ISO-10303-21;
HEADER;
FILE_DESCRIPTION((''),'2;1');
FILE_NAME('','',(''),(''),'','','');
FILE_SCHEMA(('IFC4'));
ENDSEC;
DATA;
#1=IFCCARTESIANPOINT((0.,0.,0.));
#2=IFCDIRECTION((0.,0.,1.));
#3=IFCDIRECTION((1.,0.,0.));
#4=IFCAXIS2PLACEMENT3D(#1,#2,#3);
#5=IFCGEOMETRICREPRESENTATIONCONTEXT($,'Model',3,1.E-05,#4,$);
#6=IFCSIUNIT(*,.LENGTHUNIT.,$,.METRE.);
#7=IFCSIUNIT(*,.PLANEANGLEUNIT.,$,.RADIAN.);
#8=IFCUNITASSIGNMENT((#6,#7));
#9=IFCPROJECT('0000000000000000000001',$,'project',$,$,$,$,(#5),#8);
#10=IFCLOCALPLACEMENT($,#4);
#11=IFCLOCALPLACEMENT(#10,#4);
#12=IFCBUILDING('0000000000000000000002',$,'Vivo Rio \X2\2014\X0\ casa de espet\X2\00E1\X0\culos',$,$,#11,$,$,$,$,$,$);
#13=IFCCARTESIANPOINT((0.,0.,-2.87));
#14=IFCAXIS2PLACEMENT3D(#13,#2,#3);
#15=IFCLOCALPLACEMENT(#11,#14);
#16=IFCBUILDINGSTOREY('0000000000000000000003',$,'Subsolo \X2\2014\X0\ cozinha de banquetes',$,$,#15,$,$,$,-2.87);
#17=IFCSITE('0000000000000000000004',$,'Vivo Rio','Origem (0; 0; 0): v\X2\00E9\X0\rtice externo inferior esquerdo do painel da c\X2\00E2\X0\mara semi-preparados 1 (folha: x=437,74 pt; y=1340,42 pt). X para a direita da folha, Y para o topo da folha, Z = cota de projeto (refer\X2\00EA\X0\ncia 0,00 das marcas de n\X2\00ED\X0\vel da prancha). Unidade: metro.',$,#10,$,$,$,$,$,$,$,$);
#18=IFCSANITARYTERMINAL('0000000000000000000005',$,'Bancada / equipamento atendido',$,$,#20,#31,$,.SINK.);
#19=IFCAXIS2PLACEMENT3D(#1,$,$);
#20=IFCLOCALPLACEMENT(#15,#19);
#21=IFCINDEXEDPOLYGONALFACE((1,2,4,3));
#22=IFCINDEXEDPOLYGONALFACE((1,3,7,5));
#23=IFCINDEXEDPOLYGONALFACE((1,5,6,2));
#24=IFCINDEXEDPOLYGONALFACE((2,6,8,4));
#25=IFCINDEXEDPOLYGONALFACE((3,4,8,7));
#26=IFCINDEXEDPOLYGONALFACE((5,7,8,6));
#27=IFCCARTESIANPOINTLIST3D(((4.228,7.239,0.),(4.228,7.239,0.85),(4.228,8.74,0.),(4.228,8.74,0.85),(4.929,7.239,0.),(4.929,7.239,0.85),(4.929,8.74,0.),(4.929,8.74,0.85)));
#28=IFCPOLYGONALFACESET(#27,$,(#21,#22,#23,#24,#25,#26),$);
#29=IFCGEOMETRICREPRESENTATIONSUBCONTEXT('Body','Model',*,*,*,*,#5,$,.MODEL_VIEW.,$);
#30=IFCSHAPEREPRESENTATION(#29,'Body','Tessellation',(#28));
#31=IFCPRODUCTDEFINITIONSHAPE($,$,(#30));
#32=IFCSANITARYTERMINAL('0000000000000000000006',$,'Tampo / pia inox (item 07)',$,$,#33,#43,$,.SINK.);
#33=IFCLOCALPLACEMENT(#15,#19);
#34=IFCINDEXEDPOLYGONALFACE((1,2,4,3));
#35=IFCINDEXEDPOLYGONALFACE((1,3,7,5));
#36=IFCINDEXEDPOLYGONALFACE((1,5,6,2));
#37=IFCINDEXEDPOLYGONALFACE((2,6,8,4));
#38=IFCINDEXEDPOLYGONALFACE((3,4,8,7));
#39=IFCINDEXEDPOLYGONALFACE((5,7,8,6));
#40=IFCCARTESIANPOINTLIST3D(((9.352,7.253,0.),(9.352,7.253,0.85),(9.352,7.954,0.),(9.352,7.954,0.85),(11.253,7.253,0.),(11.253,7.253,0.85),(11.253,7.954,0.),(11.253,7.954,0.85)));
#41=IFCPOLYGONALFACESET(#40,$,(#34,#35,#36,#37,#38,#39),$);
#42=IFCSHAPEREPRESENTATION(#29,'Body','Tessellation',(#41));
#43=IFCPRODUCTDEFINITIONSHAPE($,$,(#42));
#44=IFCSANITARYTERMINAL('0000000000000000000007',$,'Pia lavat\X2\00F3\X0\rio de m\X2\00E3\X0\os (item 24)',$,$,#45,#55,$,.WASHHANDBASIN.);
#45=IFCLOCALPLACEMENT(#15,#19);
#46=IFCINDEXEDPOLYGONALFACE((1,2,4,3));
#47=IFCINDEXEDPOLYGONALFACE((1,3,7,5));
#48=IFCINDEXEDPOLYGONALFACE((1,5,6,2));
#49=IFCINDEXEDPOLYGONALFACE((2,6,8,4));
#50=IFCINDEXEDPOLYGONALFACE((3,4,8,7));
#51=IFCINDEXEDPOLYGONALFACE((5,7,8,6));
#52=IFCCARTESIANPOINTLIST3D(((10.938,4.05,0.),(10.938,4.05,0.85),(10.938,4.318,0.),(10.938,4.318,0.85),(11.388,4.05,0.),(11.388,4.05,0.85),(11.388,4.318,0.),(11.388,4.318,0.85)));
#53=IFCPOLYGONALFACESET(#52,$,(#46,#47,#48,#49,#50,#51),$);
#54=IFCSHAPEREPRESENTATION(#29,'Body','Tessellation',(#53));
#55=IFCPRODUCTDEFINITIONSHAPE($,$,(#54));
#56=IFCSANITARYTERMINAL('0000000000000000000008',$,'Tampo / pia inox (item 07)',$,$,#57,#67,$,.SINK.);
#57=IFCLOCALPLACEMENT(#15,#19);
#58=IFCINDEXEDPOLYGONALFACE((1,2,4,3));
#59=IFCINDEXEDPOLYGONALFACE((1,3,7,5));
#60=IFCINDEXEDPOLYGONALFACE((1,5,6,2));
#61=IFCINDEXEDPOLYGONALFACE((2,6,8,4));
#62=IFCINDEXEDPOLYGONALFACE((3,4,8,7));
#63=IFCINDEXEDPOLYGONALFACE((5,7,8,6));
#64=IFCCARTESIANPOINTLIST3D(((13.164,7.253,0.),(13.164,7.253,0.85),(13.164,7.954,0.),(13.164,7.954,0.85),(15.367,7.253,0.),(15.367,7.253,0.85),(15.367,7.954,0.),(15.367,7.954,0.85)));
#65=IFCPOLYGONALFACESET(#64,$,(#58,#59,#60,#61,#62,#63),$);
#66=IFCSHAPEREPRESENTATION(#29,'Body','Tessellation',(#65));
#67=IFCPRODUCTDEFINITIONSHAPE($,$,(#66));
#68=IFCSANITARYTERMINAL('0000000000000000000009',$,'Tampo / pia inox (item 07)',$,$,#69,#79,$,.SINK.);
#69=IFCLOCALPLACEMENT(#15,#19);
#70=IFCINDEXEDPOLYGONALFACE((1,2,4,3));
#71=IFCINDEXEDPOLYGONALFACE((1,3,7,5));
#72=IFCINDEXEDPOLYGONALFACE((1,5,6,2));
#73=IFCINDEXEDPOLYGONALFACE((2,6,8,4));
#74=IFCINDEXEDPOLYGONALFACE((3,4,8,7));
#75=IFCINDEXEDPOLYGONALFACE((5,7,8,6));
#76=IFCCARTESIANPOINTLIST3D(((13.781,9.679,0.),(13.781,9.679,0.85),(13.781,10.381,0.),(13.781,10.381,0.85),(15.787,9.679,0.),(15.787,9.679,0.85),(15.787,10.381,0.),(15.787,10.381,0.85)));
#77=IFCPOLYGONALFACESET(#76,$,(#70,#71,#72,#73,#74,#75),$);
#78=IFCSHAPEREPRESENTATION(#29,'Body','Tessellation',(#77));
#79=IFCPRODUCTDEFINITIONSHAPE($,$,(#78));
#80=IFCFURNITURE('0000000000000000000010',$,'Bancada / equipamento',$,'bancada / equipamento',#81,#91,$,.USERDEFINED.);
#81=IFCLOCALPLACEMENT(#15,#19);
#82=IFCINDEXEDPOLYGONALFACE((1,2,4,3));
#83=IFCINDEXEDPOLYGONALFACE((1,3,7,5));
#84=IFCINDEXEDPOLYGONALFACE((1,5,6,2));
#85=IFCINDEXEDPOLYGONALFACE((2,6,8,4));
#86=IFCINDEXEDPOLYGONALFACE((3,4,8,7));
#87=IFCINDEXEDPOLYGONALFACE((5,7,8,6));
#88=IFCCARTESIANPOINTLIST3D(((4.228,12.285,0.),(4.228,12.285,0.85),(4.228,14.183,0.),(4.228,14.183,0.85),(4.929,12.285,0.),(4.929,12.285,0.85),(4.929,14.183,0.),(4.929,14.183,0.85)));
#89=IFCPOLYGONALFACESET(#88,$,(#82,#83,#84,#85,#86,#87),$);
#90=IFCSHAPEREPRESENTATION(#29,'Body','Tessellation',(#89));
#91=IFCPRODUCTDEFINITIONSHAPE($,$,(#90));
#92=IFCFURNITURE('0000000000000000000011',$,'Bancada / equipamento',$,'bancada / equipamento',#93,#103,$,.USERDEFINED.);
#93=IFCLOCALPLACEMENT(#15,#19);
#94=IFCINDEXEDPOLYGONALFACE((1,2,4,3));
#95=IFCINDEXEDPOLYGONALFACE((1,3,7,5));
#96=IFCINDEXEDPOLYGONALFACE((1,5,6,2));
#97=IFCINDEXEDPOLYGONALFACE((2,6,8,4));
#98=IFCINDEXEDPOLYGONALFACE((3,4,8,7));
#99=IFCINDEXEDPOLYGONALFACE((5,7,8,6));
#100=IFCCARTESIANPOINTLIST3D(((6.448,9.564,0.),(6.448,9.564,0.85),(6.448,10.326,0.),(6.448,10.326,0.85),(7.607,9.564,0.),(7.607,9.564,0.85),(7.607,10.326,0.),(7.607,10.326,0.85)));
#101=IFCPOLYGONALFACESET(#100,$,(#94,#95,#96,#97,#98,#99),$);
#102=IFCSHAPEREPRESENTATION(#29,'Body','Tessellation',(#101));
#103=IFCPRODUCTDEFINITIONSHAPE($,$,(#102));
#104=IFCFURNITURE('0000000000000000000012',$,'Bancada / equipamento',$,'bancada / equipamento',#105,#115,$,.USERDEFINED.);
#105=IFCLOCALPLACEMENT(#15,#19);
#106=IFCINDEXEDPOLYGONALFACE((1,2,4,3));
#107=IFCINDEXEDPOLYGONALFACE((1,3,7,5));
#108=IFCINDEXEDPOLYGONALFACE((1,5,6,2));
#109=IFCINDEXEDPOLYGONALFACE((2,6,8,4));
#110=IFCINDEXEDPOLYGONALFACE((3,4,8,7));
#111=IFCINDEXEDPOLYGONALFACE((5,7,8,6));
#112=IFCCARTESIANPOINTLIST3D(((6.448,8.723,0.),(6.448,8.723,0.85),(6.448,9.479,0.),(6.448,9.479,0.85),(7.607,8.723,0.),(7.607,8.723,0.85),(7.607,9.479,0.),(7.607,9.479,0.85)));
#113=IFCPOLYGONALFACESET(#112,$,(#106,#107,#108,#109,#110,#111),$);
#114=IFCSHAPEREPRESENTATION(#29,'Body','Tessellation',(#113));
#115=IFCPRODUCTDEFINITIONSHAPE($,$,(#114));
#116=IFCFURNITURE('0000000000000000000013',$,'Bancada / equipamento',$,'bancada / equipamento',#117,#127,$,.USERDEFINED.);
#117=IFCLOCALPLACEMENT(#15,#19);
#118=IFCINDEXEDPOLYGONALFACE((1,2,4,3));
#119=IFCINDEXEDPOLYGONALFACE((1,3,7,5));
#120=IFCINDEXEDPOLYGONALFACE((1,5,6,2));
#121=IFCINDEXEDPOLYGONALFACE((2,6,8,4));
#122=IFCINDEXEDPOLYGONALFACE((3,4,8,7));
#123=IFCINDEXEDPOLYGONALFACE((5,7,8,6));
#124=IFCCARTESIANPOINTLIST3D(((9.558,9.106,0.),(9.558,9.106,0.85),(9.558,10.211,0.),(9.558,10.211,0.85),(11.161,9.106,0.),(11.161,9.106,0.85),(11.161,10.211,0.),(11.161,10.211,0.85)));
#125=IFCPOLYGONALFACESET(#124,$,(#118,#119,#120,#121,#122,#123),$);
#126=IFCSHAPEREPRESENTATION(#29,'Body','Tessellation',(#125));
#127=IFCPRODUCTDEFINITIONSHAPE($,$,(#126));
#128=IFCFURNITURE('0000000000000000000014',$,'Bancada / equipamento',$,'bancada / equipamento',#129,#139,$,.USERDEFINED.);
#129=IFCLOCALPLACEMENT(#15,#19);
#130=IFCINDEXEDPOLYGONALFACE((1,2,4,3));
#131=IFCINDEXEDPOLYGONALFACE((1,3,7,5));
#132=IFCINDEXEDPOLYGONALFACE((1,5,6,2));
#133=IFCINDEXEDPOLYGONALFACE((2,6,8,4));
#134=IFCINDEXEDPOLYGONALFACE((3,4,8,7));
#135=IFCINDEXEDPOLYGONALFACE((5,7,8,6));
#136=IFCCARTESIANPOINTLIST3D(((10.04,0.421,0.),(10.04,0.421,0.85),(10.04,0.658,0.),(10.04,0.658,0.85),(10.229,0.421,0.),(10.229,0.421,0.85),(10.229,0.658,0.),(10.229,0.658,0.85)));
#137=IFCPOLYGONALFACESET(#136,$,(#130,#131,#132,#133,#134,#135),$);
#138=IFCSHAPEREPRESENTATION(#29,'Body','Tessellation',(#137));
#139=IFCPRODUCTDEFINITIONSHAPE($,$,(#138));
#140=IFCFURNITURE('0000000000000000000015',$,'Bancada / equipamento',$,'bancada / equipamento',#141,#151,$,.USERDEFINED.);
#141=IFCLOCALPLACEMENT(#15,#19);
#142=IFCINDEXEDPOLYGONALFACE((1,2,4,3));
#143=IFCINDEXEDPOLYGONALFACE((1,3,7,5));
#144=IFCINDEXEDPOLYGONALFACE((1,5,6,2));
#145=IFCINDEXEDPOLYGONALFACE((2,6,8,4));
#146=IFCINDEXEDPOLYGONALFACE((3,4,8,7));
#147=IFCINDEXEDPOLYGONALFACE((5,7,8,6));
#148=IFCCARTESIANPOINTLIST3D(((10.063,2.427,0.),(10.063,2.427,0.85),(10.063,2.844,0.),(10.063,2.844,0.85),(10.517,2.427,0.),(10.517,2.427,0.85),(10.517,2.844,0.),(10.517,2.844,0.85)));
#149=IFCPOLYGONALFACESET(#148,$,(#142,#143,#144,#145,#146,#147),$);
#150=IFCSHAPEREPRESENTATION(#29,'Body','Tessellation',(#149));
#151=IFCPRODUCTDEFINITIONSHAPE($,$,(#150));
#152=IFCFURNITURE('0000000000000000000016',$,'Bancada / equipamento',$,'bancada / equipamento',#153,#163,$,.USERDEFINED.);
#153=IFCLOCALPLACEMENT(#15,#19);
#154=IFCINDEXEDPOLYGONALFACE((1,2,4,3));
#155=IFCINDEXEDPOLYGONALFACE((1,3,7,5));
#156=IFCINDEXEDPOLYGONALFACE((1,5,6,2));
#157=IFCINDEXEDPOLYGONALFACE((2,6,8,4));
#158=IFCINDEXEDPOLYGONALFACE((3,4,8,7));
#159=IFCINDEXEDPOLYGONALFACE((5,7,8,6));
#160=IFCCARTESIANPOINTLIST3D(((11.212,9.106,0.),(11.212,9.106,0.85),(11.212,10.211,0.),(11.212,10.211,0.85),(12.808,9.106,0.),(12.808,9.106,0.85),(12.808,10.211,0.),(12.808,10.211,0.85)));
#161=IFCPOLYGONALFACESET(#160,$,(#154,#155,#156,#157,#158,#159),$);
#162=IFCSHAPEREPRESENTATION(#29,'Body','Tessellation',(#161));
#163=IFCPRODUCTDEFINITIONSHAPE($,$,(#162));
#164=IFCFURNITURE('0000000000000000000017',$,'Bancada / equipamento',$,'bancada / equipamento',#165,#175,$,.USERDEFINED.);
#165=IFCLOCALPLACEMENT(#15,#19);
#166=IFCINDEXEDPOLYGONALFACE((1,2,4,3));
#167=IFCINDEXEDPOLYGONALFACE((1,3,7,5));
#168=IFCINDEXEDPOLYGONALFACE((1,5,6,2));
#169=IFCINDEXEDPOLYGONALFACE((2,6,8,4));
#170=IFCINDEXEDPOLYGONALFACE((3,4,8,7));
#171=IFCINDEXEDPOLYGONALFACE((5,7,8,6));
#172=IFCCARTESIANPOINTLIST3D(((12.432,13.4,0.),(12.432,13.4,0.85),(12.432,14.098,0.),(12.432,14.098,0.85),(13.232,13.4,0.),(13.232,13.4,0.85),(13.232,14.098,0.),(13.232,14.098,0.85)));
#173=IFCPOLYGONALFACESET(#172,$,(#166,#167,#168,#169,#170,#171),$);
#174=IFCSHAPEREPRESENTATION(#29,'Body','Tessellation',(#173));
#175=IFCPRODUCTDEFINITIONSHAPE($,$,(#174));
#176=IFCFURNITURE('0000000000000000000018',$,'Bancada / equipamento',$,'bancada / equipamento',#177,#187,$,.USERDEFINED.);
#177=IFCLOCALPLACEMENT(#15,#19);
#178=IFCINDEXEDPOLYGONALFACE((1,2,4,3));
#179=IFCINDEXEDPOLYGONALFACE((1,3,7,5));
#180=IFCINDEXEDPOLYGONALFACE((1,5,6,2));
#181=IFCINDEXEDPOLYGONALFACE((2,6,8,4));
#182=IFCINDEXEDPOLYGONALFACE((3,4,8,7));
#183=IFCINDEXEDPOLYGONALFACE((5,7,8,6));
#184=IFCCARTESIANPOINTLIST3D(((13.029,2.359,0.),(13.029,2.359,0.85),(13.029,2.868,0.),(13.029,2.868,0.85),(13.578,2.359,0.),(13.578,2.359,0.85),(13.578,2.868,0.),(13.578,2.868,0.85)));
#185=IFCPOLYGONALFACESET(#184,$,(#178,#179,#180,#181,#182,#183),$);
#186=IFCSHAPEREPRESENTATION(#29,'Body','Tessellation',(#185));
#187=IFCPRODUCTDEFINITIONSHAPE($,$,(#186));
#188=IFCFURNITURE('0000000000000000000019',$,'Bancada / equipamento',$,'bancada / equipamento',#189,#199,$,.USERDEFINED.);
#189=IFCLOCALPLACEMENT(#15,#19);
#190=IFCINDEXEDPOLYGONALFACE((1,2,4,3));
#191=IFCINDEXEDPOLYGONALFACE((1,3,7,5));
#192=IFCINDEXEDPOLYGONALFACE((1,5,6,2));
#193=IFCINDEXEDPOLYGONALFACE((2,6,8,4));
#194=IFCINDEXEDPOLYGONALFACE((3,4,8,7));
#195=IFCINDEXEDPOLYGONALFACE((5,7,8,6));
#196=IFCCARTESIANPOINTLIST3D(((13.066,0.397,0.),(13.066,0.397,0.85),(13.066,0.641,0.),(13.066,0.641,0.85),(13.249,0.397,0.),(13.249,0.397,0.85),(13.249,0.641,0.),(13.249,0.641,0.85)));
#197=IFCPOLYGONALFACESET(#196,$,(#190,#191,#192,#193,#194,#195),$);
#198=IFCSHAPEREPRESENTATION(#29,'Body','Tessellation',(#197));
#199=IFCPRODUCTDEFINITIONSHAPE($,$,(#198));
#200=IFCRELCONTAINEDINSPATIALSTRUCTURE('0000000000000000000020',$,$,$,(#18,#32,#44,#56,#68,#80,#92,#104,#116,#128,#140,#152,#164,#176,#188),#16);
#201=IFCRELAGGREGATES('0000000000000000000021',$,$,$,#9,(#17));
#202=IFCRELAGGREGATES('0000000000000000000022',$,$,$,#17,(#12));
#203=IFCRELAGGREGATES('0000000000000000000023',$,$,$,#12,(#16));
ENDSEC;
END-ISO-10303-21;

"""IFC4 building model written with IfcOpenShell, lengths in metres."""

from ifc_helpers import new_model, si_unit, frame, origin_with_axes, origin_2d, place, context, subcontext, project, spatial, rectangle, extrude, element, save


model = new_model("IFC4")

# Units and contexts
model_context = context("Model", 3, precision=1e-05, world=origin_with_axes())
body_context = subcontext(model_context, "Body", "Model", "MODEL_VIEW")
ifc_project = project(units=[si_unit("LENGTHUNIT", "METRE"), si_unit("PLANEANGLEUNIT", "RADIAN")], contexts=[model_context])

# Site, building, storey
site_placement = place(None, origin_with_axes())
site = spatial("IfcSite", under=ifc_project, at=site_placement, Name="Vivo Rio", Description="Origem (0; 0; 0): vértice externo inferior esquerdo do painel da câmara semi-preparados 1 (folha: x=437,74 pt; y=1340,42 pt). X para a direita da folha, Y para o topo da folha, Z = cota de projeto (referência 0,00 das marcas de nível da prancha). Unidade: metro.")
building_placement = place(site_placement, origin_with_axes())
building = spatial("IfcBuilding", under=site, at=building_placement, Name="Vivo Rio — casa de espetáculos")
storey_placement = place(building_placement, frame((0.0, 0.0, -2.87), z_axis=(0.0, 0.0, 1.0), x_axis=(1.0, 0.0, 0.0)))
storey = spatial("IfcBuildingStorey", under=building, at=storey_placement, Name="Subsolo — cozinha de banquetes", Elevation=-2.87)

# Sanitary terminals
sanitary_terminal_1_placement = place(storey_placement, origin_with_axes())
element("IfcSanitaryTerminal", 1, at=sanitary_terminal_1_placement, inside=storey, Name="Bancada / equipamento atendido", PredefinedType="SINK", context=body_context, shape_type="SweptSolid", body=[
    extrude(rectangle(XDim=0.701, YDim=1.501, at=origin_2d()), frame((4.5785, 7.9895, 0.0), z_axis=(0.0, 0.0, 1.0), x_axis=(1.0, 0.0, 0.0)), (0.0, 0.0, 1.0), 0.85),
])
sanitary_terminal_2_placement = place(storey_placement, origin_with_axes())
element("IfcSanitaryTerminal", 2, at=sanitary_terminal_2_placement, inside=storey, Name="Tampo / pia inox (item 07)", PredefinedType="SINK", context=body_context, shape_type="SweptSolid", body=[
    extrude(rectangle(XDim=1.901, YDim=0.701, at=origin_2d()), frame((10.3025, 7.6035, 0.0), z_axis=(0.0, 0.0, 1.0), x_axis=(1.0, 0.0, 0.0)), (0.0, 0.0, 1.0), 0.85),
])
sanitary_terminal_3_placement = place(storey_placement, origin_with_axes())
element("IfcSanitaryTerminal", 3, at=sanitary_terminal_3_placement, inside=storey, Name="Pia lavatório de mãos (item 24)", PredefinedType="WASHHANDBASIN", context=body_context, shape_type="SweptSolid", body=[
    extrude(rectangle(XDim=0.45, YDim=0.268, at=origin_2d()), frame((11.163, 4.184, 0.0), z_axis=(0.0, 0.0, 1.0), x_axis=(1.0, 0.0, 0.0)), (0.0, 0.0, 1.0), 0.85),
])
sanitary_terminal_4_placement = place(storey_placement, origin_with_axes())
element("IfcSanitaryTerminal", 4, at=sanitary_terminal_4_placement, inside=storey, Name="Tampo / pia inox (item 07)", PredefinedType="SINK", context=body_context, shape_type="SweptSolid", body=[
    extrude(rectangle(XDim=2.203, YDim=0.701, at=origin_2d()), frame((14.2655, 7.6035, 0.0), z_axis=(0.0, 0.0, 1.0), x_axis=(1.0, 0.0, 0.0)), (0.0, 0.0, 1.0), 0.85),
])
sanitary_terminal_5_placement = place(storey_placement, origin_with_axes())
element("IfcSanitaryTerminal", 5, at=sanitary_terminal_5_placement, inside=storey, Name="Tampo / pia inox (item 07)", PredefinedType="SINK", context=body_context, shape_type="SweptSolid", body=[
    extrude(rectangle(XDim=2.006, YDim=0.702, at=origin_2d()), frame((14.784, 10.03, 0.0), z_axis=(0.0, 0.0, 1.0), x_axis=(1.0, 0.0, 0.0)), (0.0, 0.0, 1.0), 0.85),
])

# Furniture
furniture_1_placement = place(storey_placement, origin_with_axes())
element("IfcFurniture", 6, at=furniture_1_placement, inside=storey, Name="Bancada / equipamento", ObjectType="bancada / equipamento", PredefinedType="USERDEFINED", context=body_context, shape_type="SweptSolid", body=[
    extrude(rectangle(XDim=0.701, YDim=1.898, at=origin_2d()), frame((4.5785, 13.234, 0.0), z_axis=(0.0, 0.0, 1.0), x_axis=(1.0, 0.0, 0.0)), (0.0, 0.0, 1.0), 0.85),
])
furniture_2_placement = place(storey_placement, origin_with_axes())
element("IfcFurniture", 7, at=furniture_2_placement, inside=storey, Name="Bancada / equipamento", ObjectType="bancada / equipamento", PredefinedType="USERDEFINED", context=body_context, shape_type="SweptSolid", body=[
    extrude(rectangle(XDim=1.159, YDim=0.762, at=origin_2d()), frame((7.0275, 9.945, 0.0), z_axis=(0.0, 0.0, 1.0), x_axis=(1.0, 0.0, 0.0)), (0.0, 0.0, 1.0), 0.85),
])
furniture_3_placement = place(storey_placement, origin_with_axes())
element("IfcFurniture", 8, at=furniture_3_placement, inside=storey, Name="Bancada / equipamento", ObjectType="bancada / equipamento", PredefinedType="USERDEFINED", context=body_context, shape_type="SweptSolid", body=[
    extrude(rectangle(XDim=1.159, YDim=0.756, at=origin_2d()), frame((7.0275, 9.101, 0.0), z_axis=(0.0, 0.0, 1.0), x_axis=(1.0, 0.0, 0.0)), (0.0, 0.0, 1.0), 0.85),
])
furniture_4_placement = place(storey_placement, origin_with_axes())
element("IfcFurniture", 9, at=furniture_4_placement, inside=storey, Name="Bancada / equipamento", ObjectType="bancada / equipamento", PredefinedType="USERDEFINED", context=body_context, shape_type="SweptSolid", body=[
    extrude(rectangle(XDim=1.603, YDim=1.105, at=origin_2d()), frame((10.3595, 9.6585, 0.0), z_axis=(0.0, 0.0, 1.0), x_axis=(1.0, 0.0, 0.0)), (0.0, 0.0, 1.0), 0.85),
])
furniture_5_placement = place(storey_placement, origin_with_axes())
element("IfcFurniture", 10, at=furniture_5_placement, inside=storey, Name="Bancada / equipamento", ObjectType="bancada / equipamento", PredefinedType="USERDEFINED", context=body_context, shape_type="SweptSolid", body=[
    extrude(rectangle(XDim=0.189, YDim=0.237, at=origin_2d()), frame((10.1345, 0.5395, 0.0), z_axis=(0.0, 0.0, 1.0), x_axis=(1.0, 0.0, 0.0)), (0.0, 0.0, 1.0), 0.85),
])
furniture_6_placement = place(storey_placement, origin_with_axes())
element("IfcFurniture", 11, at=furniture_6_placement, inside=storey, Name="Bancada / equipamento", ObjectType="bancada / equipamento", PredefinedType="USERDEFINED", context=body_context, shape_type="SweptSolid", body=[
    extrude(rectangle(XDim=0.454, YDim=0.417, at=origin_2d()), frame((10.29, 2.6355, 0.0), z_axis=(0.0, 0.0, 1.0), x_axis=(1.0, 0.0, 0.0)), (0.0, 0.0, 1.0), 0.85),
])
furniture_7_placement = place(storey_placement, origin_with_axes())
element("IfcFurniture", 12, at=furniture_7_placement, inside=storey, Name="Bancada / equipamento", ObjectType="bancada / equipamento", PredefinedType="USERDEFINED", context=body_context, shape_type="SweptSolid", body=[
    extrude(rectangle(XDim=1.596, YDim=1.105, at=origin_2d()), frame((12.01, 9.6585, 0.0), z_axis=(0.0, 0.0, 1.0), x_axis=(1.0, 0.0, 0.0)), (0.0, 0.0, 1.0), 0.85),
])
furniture_8_placement = place(storey_placement, origin_with_axes())
element("IfcFurniture", 13, at=furniture_8_placement, inside=storey, Name="Bancada / equipamento", ObjectType="bancada / equipamento", PredefinedType="USERDEFINED", context=body_context, shape_type="SweptSolid", body=[
    extrude(rectangle(XDim=0.8, YDim=0.698, at=origin_2d()), frame((12.832, 13.749, 0.0), z_axis=(0.0, 0.0, 1.0), x_axis=(1.0, 0.0, 0.0)), (0.0, 0.0, 1.0), 0.85),
])
furniture_9_placement = place(storey_placement, origin_with_axes())
element("IfcFurniture", 14, at=furniture_9_placement, inside=storey, Name="Bancada / equipamento", ObjectType="bancada / equipamento", PredefinedType="USERDEFINED", context=body_context, shape_type="SweptSolid", body=[
    extrude(rectangle(XDim=0.549, YDim=0.509, at=origin_2d()), frame((13.3035, 2.6135, 0.0), z_axis=(0.0, 0.0, 1.0), x_axis=(1.0, 0.0, 0.0)), (0.0, 0.0, 1.0), 0.85),
])
furniture_10_placement = place(storey_placement, origin_with_axes())
element("IfcFurniture", 15, at=furniture_10_placement, inside=storey, Name="Bancada / equipamento", ObjectType="bancada / equipamento", PredefinedType="USERDEFINED", context=body_context, shape_type="SweptSolid", body=[
    extrude(rectangle(XDim=0.183, YDim=0.244, at=origin_2d()), frame((13.1575, 0.519, 0.0), z_axis=(0.0, 0.0, 1.0), x_axis=(1.0, 0.0, 0.0)), (0.0, 0.0, 1.0), 0.85),
])

save(model, "model.ifc")
